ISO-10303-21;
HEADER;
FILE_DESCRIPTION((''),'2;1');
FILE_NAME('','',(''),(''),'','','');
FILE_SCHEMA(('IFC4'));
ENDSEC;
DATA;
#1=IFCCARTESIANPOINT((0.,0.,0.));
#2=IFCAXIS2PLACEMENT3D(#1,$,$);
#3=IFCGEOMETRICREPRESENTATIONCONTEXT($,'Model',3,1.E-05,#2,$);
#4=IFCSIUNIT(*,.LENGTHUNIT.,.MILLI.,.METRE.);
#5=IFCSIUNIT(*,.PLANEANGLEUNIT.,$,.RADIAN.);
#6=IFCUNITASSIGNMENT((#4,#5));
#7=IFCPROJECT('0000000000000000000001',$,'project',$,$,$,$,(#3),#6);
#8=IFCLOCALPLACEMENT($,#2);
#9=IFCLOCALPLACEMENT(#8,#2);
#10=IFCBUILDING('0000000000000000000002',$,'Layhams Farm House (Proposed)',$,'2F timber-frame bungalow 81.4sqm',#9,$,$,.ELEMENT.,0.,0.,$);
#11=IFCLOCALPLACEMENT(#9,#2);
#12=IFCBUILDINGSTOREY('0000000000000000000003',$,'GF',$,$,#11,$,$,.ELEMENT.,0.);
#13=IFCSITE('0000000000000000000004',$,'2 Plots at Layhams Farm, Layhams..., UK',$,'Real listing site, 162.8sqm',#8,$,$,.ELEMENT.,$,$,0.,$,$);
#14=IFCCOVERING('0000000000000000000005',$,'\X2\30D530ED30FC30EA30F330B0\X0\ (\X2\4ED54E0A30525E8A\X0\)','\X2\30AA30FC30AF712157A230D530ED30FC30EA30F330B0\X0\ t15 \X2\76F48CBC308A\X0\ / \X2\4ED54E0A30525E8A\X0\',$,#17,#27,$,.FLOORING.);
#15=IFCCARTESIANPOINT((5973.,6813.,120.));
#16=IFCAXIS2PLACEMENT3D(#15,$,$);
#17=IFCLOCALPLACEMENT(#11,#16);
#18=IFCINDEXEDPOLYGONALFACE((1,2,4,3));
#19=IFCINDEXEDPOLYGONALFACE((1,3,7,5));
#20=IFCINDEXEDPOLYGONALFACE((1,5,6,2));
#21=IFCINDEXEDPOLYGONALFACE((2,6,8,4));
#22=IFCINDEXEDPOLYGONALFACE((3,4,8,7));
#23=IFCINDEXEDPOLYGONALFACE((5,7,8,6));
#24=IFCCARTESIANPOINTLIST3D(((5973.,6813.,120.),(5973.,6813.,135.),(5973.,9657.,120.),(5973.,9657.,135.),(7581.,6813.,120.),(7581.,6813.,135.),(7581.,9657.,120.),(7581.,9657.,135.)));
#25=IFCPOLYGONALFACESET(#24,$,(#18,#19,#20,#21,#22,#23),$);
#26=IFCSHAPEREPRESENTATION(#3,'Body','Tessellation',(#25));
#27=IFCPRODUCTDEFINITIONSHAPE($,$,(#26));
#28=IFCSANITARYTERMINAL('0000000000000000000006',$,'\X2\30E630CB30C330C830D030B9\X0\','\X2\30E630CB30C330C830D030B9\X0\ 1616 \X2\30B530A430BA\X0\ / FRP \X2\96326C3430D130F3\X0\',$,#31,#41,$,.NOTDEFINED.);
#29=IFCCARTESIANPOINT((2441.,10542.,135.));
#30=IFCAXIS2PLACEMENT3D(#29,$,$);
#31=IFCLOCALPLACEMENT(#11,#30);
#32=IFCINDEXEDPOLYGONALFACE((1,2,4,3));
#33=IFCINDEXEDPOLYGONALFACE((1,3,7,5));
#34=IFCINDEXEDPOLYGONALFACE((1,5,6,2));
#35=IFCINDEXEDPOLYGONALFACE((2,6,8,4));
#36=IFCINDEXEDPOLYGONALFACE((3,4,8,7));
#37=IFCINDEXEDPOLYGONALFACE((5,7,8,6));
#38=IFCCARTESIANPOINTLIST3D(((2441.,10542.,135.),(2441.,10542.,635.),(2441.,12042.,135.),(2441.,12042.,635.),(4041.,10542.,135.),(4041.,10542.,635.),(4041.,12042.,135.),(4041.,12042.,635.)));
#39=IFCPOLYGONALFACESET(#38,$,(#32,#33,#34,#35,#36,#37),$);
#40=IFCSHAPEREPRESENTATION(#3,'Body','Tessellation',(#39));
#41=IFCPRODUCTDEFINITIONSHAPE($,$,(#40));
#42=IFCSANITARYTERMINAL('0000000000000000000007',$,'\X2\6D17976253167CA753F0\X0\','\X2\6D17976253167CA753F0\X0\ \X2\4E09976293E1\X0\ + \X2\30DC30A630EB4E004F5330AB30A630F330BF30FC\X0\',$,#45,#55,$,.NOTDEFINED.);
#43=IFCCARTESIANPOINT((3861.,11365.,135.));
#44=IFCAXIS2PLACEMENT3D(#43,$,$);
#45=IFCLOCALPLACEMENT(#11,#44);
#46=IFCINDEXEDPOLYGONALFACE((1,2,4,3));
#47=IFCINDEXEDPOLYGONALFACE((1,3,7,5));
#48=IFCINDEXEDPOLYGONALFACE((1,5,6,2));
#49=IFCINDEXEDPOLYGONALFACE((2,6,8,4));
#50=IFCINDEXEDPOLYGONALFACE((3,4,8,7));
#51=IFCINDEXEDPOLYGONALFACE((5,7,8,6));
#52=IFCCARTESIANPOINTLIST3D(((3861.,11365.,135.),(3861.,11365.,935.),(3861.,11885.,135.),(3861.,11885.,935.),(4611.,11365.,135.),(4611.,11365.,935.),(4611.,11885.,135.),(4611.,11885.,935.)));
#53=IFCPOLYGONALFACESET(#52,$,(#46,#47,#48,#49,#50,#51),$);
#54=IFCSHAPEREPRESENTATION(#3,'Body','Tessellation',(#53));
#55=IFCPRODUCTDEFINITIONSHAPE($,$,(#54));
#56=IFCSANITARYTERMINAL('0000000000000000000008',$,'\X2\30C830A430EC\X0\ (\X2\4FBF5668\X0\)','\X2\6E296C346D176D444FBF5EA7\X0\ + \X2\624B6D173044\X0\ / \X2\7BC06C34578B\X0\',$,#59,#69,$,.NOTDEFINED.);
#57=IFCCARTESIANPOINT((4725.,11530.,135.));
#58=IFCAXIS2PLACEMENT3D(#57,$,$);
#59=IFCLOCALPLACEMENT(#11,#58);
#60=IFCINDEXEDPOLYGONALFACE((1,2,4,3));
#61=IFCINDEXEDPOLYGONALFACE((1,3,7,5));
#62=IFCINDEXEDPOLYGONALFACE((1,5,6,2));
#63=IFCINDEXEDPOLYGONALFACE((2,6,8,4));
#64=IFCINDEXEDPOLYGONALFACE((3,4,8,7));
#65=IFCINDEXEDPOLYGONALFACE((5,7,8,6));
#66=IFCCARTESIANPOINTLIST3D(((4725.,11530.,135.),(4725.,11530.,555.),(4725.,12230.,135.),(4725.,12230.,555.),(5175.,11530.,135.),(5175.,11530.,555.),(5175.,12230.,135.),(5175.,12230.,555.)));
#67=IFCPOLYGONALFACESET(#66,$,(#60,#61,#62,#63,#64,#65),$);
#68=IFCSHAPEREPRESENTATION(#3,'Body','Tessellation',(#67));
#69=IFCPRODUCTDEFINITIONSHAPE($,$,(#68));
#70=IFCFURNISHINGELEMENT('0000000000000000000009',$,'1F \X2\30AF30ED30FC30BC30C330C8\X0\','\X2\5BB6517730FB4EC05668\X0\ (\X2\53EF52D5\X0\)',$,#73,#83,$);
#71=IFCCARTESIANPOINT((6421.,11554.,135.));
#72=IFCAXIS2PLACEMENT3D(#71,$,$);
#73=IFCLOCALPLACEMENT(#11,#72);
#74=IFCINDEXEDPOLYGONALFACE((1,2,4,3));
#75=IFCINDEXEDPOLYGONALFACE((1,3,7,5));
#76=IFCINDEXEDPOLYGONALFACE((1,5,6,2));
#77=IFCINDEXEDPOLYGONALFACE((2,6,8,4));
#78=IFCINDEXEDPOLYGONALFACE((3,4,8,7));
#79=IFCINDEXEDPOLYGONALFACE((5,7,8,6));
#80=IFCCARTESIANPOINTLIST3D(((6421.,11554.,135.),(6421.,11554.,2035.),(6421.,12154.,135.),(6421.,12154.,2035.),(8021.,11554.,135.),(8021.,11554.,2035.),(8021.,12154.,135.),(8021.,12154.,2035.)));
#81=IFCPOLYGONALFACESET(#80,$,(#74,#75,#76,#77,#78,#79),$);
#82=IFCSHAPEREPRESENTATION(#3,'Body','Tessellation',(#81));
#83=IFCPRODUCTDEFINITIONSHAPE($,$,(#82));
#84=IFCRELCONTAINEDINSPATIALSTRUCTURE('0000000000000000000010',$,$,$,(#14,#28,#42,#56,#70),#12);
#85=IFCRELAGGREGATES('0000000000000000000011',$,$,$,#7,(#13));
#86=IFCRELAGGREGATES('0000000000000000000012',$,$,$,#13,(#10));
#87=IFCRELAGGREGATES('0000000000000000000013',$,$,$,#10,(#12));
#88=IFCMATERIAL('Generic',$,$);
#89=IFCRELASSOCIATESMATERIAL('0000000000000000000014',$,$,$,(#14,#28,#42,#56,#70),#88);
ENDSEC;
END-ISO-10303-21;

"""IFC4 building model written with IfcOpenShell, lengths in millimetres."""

from ifc_helpers import new_model, si_unit, frame, frame_2d, origin, place, context, project, spatial, rectangle, extrude, material, element, save


model = new_model("IFC4")

# Units and contexts
model_context = context("Model", 3, precision=1e-05, world=origin())
ifc_project = project(units=[si_unit("LENGTHUNIT", "METRE", prefix="MILLI"), si_unit("PLANEANGLEUNIT", "RADIAN")], contexts=[model_context])

# Site, building, storey
site_placement = place(None, origin())
site = spatial("IfcSite", under=ifc_project, at=site_placement, Name="2 Plots at Layhams Farm, Layhams..., UK", ObjectType="Real listing site, 162.8sqm", CompositionType="ELEMENT", RefElevation=0.0)
building_placement = place(site_placement, origin())
building = spatial("IfcBuilding", under=site, at=building_placement, Name="Layhams Farm House (Proposed)", ObjectType="2F timber-frame bungalow 81.4sqm", CompositionType="ELEMENT", ElevationOfRefHeight=0.0, ElevationOfTerrain=0.0)
storey_placement = place(building_placement, origin())
storey = spatial("IfcBuildingStorey", under=building, at=storey_placement, Name="GF", CompositionType="ELEMENT", Elevation=0.0)

# Covering
ifc_material_1 = material(Name="Generic")
covering_1_placement = place(storey_placement, frame((5973.0, 6813.0, 120.0)))
element("IfcCovering", 1, at=covering_1_placement, inside=storey, material=ifc_material_1, Name="フローリング (仕上げ床)", Description="オーク無垢フローリング t15 直貼り / 仕上げ床", PredefinedType="FLOORING", context=model_context, shape_type="SweptSolid", body=[
    extrude(rectangle(XDim=1608.0, YDim=2844.0, at=frame_2d((804.0, 1422.0))), frame((5973.0, 6813.0, 120.0)), (0.0, 0.0, 1.0), 15.0),
])

# Sanitary terminals
sanitary_terminal_1_placement = place(storey_placement, frame((2441.0, 10542.0, 135.0)))
element("IfcSanitaryTerminal", 2, at=sanitary_terminal_1_placement, inside=storey, material=ifc_material_1, Name="ユニットバス", Description="ユニットバス 1616 サイズ / FRP 防水パン", PredefinedType="NOTDEFINED", context=model_context, shape_type="SweptSolid", body=[
    extrude(rectangle(XDim=1600.0, YDim=1500.0, at=frame_2d((800.0, 750.0))), frame((2441.0, 10542.0, 135.0)), (0.0, 0.0, 1.0), 500.0),
])
sanitary_terminal_2_placement = place(storey_placement, frame((3861.0, 11365.0, 135.0)))
element("IfcSanitaryTerminal", 3, at=sanitary_terminal_2_placement, inside=storey, material=ifc_material_1, Name="洗面化粧台", Description="洗面化粧台 三面鏡 + ボウル一体カウンター", PredefinedType="NOTDEFINED", context=model_context, shape_type="SweptSolid", body=[
    extrude(rectangle(XDim=750.0, YDim=520.0, at=frame_2d((375.0, 260.0))), frame((3861.0, 11365.0, 135.0)), (0.0, 0.0, 1.0), 800.0),
])
sanitary_terminal_3_placement = place(storey_placement, frame((4725.0, 11530.0, 135.0)))
element("IfcSanitaryTerminal", 4, at=sanitary_terminal_3_placement, inside=storey, material=ifc_material_1, Name="トイレ (便器)", Description="温水洗浄便座 + 手洗い / 節水型", PredefinedType="NOTDEFINED", context=model_context, shape_type="SweptSolid", body=[
    extrude(rectangle(XDim=450.0, YDim=700.0, at=frame_2d((225.0, 350.0))), frame((4725.0, 11530.0, 135.0)), (0.0, 0.0, 1.0), 420.0),
])

# Furnishing element
furnishing_placement = place(storey_placement, frame((6421.0, 11554.0, 135.0)))
element("IfcFurnishingElement", 5, at=furnishing_placement, inside=storey, material=ifc_material_1, Name="1F クローゼット", Description="家具・什器 (可動)", context=model_context, shape_type="SweptSolid", body=[
    extrude(rectangle(XDim=1600.0, YDim=600.0, at=frame_2d((800.0, 300.0))), frame((6421.0, 11554.0, 135.0)), (0.0, 0.0, 1.0), 1900.0),
])

save(model, "model.ifc")
